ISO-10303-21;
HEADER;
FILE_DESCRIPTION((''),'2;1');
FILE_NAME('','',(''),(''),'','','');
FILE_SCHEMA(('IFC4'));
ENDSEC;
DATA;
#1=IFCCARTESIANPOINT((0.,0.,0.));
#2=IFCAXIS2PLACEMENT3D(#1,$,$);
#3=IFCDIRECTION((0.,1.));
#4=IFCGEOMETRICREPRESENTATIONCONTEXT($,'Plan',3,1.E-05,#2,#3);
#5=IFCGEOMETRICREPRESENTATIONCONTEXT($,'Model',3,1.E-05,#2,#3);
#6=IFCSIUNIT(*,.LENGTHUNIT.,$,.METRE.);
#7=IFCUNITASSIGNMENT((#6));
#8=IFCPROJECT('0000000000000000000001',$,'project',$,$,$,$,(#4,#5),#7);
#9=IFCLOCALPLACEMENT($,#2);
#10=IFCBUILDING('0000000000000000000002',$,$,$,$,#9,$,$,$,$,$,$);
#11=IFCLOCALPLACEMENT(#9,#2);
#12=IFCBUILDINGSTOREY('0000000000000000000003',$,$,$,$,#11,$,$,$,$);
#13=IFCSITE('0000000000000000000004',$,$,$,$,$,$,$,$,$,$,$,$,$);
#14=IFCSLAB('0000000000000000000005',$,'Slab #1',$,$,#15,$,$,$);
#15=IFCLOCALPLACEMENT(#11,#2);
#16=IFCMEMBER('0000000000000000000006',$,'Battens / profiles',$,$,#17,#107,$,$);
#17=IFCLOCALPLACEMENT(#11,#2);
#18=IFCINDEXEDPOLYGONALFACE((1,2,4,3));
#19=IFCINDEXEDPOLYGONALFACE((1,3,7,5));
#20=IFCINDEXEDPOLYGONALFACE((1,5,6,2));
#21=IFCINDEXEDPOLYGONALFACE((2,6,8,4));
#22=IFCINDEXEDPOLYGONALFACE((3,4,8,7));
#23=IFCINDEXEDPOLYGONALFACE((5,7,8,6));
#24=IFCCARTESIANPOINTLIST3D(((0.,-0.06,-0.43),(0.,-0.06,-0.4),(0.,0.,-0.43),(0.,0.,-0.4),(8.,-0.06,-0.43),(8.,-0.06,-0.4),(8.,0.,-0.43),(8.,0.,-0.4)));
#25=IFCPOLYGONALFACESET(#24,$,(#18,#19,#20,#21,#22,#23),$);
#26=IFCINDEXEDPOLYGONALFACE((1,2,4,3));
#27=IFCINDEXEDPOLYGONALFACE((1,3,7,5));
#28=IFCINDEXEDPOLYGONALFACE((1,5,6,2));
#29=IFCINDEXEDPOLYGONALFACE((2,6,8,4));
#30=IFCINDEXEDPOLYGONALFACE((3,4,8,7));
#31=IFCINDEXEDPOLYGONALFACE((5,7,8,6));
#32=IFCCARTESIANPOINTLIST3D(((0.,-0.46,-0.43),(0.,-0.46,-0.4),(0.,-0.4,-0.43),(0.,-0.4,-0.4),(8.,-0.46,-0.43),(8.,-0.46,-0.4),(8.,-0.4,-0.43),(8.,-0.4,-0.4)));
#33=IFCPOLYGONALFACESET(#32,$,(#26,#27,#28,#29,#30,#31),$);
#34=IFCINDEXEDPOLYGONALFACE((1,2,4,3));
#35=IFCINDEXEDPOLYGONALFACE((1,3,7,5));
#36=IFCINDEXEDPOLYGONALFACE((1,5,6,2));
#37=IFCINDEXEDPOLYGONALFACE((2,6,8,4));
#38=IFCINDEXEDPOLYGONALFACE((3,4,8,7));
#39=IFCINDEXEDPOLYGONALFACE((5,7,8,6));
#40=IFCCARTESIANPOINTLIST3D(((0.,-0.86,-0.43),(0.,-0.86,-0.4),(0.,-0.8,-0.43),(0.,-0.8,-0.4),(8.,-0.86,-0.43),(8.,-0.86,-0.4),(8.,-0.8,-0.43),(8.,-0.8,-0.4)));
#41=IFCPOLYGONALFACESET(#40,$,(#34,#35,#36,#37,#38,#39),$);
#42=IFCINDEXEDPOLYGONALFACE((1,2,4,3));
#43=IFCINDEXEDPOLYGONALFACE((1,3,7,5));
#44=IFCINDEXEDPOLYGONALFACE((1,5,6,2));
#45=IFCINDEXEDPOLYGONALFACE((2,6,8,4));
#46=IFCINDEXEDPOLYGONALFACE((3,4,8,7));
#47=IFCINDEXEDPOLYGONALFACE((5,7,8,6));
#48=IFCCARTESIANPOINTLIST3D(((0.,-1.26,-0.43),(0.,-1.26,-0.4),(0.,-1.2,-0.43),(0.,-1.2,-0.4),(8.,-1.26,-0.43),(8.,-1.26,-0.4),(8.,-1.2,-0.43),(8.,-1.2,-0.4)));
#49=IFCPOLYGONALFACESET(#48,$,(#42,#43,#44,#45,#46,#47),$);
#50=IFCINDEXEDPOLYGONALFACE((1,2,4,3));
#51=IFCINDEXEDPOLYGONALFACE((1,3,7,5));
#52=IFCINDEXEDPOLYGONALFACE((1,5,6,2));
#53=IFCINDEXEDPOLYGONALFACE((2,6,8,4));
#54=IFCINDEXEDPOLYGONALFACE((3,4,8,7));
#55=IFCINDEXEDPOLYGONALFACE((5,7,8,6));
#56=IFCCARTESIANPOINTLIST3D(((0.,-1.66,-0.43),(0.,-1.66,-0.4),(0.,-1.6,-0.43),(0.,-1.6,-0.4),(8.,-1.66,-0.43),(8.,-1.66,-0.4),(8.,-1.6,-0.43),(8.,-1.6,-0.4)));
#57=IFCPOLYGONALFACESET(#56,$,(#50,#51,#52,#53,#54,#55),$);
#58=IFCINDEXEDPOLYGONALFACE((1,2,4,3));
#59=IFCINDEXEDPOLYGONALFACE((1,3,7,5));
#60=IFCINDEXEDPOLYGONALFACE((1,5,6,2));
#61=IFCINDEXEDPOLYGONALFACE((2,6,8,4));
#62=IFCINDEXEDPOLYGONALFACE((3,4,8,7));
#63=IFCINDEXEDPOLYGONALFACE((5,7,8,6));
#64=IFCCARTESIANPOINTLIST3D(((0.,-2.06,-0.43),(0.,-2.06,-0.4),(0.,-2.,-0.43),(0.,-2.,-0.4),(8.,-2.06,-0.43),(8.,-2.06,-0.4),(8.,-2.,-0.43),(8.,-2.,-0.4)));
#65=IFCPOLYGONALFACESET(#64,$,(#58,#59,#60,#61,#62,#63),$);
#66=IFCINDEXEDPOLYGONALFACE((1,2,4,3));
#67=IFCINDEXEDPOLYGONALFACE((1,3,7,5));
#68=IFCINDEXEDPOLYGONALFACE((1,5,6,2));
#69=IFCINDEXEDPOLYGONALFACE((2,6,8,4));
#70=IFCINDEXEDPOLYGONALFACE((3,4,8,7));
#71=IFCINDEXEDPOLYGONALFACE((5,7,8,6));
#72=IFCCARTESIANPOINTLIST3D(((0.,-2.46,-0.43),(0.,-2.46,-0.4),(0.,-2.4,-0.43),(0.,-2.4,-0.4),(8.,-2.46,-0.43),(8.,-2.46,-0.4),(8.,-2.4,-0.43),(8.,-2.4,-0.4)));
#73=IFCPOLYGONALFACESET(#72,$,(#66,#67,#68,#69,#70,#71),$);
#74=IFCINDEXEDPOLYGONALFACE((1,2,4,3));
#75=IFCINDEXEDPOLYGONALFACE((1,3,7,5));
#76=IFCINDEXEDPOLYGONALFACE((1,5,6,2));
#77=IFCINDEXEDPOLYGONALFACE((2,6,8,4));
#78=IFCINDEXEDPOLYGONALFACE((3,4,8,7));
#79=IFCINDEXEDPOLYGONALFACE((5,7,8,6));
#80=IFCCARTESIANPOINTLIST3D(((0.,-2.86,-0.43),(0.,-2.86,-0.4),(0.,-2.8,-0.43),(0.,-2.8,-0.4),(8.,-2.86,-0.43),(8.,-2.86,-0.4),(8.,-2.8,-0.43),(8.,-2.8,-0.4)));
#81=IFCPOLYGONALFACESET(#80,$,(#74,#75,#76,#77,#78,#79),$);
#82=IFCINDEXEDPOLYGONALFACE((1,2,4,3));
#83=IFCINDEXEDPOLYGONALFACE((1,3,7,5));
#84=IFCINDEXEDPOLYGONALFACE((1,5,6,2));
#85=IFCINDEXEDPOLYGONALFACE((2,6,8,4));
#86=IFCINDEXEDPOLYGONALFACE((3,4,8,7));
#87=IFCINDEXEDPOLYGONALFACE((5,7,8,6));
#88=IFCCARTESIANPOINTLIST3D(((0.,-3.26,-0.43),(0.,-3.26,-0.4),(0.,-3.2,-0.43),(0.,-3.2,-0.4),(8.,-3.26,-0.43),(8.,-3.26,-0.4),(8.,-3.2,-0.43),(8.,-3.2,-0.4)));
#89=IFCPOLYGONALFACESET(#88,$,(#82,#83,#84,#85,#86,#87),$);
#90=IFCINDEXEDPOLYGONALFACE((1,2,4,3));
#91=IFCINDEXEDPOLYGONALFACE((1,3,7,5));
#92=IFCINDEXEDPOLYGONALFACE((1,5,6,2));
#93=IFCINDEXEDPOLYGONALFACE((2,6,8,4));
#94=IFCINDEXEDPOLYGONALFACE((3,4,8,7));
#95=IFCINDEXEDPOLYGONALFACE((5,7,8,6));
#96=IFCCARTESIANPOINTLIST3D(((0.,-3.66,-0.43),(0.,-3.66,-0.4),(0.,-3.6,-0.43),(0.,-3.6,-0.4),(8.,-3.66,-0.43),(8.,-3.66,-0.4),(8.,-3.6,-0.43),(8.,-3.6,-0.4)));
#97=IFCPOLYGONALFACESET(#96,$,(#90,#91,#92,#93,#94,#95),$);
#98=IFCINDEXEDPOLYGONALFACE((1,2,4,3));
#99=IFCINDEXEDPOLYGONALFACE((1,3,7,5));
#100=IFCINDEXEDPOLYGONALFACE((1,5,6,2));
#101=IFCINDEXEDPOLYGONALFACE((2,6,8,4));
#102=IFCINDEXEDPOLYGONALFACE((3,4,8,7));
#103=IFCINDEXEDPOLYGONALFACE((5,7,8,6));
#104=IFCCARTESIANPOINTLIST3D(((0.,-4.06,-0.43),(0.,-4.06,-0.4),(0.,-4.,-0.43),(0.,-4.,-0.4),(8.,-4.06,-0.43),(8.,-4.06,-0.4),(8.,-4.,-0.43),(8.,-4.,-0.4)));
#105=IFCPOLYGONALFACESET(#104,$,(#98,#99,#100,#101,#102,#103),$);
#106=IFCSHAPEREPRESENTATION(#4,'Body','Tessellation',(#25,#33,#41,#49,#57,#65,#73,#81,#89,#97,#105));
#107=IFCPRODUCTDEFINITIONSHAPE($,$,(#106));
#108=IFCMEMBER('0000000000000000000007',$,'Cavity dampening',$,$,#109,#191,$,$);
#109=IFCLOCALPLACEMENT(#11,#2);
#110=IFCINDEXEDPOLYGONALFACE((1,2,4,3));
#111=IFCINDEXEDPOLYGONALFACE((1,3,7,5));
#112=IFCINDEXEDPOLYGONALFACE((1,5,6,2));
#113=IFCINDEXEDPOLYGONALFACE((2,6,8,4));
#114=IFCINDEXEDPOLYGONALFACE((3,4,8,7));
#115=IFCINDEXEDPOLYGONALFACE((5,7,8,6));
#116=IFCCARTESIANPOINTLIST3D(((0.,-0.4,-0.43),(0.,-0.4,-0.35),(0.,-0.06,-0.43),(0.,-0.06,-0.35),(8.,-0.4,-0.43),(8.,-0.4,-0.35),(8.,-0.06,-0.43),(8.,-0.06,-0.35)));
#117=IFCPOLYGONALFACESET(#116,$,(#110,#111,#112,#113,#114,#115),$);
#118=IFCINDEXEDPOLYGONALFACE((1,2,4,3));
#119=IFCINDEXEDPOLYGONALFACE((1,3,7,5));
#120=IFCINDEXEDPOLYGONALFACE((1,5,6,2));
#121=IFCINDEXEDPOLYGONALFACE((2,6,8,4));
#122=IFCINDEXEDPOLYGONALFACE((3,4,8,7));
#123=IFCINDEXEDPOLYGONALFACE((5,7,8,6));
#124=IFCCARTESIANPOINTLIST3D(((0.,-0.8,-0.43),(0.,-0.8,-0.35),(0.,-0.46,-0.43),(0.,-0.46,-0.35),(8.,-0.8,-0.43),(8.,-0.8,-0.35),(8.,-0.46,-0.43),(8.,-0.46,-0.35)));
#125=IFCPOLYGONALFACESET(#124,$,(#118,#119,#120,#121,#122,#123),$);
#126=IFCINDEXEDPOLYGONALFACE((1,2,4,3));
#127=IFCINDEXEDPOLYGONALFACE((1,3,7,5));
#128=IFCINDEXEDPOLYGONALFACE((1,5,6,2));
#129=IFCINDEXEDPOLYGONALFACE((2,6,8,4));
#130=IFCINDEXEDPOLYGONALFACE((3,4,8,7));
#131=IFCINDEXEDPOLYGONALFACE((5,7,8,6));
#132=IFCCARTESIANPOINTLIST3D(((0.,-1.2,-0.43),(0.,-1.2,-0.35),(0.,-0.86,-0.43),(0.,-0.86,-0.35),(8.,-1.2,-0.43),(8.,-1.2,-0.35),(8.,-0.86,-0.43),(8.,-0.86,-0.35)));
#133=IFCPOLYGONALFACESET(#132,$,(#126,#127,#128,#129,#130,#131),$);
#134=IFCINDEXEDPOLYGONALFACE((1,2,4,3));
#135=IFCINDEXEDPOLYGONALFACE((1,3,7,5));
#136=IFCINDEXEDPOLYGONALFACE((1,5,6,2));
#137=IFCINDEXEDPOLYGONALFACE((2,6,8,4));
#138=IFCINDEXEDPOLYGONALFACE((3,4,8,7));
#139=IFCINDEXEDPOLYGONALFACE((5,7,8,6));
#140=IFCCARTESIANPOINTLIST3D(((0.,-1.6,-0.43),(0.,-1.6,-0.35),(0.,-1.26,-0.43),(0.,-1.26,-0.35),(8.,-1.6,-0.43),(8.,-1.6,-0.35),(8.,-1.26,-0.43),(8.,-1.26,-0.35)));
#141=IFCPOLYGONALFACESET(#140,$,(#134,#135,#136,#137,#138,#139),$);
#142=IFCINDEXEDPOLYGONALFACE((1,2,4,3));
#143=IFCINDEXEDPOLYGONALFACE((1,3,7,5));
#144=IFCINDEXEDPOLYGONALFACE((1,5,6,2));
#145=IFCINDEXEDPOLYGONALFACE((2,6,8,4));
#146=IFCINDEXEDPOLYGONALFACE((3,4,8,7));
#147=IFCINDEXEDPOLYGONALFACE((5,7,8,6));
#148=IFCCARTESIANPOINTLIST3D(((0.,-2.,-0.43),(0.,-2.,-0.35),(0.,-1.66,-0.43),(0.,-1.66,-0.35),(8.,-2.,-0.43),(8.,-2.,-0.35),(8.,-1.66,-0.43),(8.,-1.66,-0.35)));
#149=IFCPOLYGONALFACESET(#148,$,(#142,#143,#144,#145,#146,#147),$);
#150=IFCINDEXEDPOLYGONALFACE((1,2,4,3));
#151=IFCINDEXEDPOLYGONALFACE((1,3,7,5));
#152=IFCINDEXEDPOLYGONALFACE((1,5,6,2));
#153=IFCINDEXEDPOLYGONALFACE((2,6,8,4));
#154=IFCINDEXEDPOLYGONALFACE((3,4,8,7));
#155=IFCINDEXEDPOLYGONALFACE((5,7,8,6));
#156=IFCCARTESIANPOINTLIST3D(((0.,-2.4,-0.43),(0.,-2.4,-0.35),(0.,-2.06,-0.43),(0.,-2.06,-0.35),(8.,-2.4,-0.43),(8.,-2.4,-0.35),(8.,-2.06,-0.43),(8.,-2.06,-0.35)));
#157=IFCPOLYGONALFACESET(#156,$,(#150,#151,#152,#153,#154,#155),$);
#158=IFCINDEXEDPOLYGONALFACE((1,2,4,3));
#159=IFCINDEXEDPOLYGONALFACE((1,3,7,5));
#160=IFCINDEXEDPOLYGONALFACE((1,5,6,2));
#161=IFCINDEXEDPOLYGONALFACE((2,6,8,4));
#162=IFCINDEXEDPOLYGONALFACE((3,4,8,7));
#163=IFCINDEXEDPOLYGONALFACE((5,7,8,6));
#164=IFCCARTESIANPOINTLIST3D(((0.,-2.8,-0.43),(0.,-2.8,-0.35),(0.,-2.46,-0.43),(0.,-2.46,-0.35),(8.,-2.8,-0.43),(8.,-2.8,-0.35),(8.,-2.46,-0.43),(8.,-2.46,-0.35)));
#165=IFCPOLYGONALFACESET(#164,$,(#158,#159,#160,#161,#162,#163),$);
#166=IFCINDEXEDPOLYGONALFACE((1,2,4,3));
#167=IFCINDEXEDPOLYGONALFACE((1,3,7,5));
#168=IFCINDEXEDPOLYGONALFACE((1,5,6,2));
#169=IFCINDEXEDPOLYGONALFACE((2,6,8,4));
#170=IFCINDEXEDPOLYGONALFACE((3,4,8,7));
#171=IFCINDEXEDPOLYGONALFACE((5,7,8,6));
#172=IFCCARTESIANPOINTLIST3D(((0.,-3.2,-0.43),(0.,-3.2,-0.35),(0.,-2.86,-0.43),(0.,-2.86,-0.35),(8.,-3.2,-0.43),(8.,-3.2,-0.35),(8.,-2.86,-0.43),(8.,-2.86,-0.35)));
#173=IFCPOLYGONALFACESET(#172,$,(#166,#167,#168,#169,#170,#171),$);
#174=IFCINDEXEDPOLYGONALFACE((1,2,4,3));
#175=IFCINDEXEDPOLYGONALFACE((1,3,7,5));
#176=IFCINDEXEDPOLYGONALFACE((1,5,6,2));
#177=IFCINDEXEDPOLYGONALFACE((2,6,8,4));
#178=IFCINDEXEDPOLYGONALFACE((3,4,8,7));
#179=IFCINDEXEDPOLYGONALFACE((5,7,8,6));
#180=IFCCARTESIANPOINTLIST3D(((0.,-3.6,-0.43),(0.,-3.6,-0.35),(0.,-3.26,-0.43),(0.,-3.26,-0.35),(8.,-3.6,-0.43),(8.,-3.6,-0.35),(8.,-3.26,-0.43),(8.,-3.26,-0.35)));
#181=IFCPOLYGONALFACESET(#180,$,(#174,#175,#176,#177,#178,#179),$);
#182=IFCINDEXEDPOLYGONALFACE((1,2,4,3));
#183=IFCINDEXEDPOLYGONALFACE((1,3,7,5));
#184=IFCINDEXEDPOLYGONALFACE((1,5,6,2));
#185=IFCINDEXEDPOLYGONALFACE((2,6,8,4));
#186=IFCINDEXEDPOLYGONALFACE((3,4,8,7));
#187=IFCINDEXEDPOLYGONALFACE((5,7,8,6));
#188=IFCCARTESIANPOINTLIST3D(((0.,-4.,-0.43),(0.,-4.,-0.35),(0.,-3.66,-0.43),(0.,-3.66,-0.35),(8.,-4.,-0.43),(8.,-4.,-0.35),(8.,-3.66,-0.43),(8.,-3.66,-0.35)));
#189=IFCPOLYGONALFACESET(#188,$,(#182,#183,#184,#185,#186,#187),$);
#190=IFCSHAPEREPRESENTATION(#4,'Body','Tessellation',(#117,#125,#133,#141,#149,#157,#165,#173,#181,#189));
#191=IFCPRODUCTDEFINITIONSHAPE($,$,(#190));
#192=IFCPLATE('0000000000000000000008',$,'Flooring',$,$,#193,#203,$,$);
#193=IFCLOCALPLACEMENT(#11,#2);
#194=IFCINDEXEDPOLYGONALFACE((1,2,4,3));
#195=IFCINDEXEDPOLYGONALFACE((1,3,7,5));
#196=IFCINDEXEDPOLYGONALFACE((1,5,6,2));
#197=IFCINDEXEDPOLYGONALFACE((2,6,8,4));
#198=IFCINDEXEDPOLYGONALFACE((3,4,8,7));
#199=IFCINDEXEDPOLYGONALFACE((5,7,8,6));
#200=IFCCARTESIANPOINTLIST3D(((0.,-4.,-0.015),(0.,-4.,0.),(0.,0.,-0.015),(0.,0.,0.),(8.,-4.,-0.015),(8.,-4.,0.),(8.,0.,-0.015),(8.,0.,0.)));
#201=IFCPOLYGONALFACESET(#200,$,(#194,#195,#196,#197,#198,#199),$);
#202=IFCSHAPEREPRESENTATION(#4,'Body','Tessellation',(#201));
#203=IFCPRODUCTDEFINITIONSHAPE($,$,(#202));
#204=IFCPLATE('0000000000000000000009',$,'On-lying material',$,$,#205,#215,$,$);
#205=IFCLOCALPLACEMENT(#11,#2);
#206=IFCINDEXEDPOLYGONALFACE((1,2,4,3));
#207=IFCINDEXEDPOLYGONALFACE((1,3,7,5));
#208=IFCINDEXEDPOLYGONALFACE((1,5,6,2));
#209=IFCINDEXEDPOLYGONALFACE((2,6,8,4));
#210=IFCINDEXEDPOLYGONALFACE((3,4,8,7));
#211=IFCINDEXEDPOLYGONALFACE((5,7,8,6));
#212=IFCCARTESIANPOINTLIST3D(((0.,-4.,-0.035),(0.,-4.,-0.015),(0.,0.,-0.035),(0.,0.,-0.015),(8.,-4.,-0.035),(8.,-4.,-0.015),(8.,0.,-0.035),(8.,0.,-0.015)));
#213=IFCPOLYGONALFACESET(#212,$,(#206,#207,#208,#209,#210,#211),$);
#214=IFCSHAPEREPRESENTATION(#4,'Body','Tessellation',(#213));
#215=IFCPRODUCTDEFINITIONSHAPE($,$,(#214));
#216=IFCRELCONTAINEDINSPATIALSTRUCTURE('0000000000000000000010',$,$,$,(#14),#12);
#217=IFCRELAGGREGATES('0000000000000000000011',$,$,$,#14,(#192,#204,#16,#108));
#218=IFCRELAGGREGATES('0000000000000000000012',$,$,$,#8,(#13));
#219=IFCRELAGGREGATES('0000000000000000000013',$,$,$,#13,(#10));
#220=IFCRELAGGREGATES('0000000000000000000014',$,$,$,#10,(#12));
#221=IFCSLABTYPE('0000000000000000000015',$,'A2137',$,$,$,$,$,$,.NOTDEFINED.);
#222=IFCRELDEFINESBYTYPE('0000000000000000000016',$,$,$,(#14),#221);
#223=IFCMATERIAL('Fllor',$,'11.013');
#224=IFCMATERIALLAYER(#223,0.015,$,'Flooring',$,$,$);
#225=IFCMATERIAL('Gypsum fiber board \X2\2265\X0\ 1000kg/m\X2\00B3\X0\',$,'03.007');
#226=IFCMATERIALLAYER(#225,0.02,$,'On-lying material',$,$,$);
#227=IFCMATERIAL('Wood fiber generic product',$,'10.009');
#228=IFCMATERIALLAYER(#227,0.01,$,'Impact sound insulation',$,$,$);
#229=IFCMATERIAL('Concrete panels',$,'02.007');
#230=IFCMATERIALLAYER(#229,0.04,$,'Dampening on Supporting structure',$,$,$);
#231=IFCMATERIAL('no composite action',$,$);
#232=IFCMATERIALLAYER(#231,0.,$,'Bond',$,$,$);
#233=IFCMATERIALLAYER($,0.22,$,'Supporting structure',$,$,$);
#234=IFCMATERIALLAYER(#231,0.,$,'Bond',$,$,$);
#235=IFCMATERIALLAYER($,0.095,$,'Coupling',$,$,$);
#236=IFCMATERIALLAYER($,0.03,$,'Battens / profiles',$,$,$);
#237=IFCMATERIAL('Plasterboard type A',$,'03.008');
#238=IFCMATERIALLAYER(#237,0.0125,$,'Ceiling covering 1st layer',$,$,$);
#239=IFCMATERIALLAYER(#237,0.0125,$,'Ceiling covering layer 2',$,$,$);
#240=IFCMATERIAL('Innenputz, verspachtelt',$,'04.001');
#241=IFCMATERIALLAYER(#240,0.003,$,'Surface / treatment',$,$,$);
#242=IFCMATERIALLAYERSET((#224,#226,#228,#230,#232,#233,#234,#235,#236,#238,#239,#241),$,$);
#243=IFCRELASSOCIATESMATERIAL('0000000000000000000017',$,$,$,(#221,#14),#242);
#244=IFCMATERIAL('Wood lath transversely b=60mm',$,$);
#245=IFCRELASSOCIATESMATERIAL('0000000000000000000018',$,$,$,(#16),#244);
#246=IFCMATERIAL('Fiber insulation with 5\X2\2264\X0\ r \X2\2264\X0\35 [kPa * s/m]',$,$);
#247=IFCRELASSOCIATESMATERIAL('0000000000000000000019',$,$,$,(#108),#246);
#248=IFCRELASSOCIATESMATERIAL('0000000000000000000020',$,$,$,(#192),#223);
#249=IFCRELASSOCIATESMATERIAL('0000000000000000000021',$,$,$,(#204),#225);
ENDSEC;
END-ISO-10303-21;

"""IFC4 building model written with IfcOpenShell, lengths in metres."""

from ifc_helpers import new_model, si_unit, direction, frame, frame_2d, origin, origin_with_axes, place, context, project, spatial, rectangle, extrude, material, layer, layer_set, type_object, element, aggregate, save


model = new_model("IFC4")

# Units and contexts
plan_context = context("Plan", 3, precision=1e-05, world=origin(), true_north=direction((0.0, 1.0)))
model_context = context("Model", 3, precision=1e-05, world=origin(), true_north=direction((0.0, 1.0)))
ifc_project = project(units=[si_unit("LENGTHUNIT", "METRE")], contexts=[plan_context, model_context])

# Site, building, storey
site = spatial("IfcSite", under=ifc_project)
building_placement = place(None, origin())
building = spatial("IfcBuilding", under=site, at=building_placement)
storey_placement = place(building_placement, origin())
storey = spatial("IfcBuildingStorey", under=building, at=storey_placement)

# Slab, members, plates
ifc_material_1 = material(Name="Fllor", Category="11.013")
ifc_layer_1 = layer(ifc_material_1, 0.015, Name="Flooring")
ifc_material_2 = material(Name="Gypsum fiber board ≥ 1000kg/m³", Category="03.007")
ifc_layer_2 = layer(ifc_material_2, 0.02, Name="On-lying material")
ifc_material_3 = material(Name="Wood fiber generic product", Category="10.009")
ifc_layer_3 = layer(ifc_material_3, 0.01, Name="Impact sound insulation")
ifc_material_4 = material(Name="Concrete panels", Category="02.007")
ifc_layer_4 = layer(ifc_material_4, 0.04, Name="Dampening on Supporting structure")
ifc_material_5 = material(Name="no composite action")
ifc_layer_5 = layer(ifc_material_5, 0.0, Name="Bond")
ifc_layer_6 = layer(None, 0.22, Name="Supporting structure")
ifc_layer_7 = layer(ifc_material_5, 0.0, Name="Bond")
ifc_layer_8 = layer(None, 0.095, Name="Coupling")
ifc_layer_9 = layer(None, 0.03, Name="Battens / profiles")
ifc_material_6 = material(Name="Plasterboard type A", Category="03.008")
ifc_layer_10 = layer(ifc_material_6, 0.0125, Name="Ceiling covering 1st layer")
ifc_layer_11 = layer(ifc_material_6, 0.0125, Name="Ceiling covering layer 2")
ifc_material_7 = material(Name="Innenputz, verspachtelt", Category="04.001")
ifc_layer_12 = layer(ifc_material_7, 0.003, Name="Surface / treatment")
ifc_layer_set = layer_set([ifc_layer_1, ifc_layer_2, ifc_layer_3, ifc_layer_4, ifc_layer_5, ifc_layer_6, ifc_layer_7, ifc_layer_8, ifc_layer_9, ifc_layer_10, ifc_layer_11, ifc_layer_12])
slab_type = type_object("IfcSlabType", Name="A2137", PredefinedType="NOTDEFINED", material=ifc_layer_set)
slab_placement = place(None, frame((0.0, 0.0, 0.0), z_axis=(0.0, 0.0, -1.0), x_axis=(1.0, 0.0, 0.0)))
slab = element("IfcSlab", 1, at=slab_placement, inside=storey, type_object=slab_type, material=ifc_layer_set, Name="Slab #1")
ifc_material_8 = material(Name="Wood lath transversely b=60mm")
member_1_placement = place(slab_placement, origin())
member_1 = element("IfcMember", 2, at=member_1_placement, material=ifc_material_8, Name="Battens / profiles", context=plan_context, shape_type="SweptSolid", body=[
    extrude(rectangle(XDim=0.06, YDim=0.03, at=frame_2d((0.03, 0.015), x_axis=(1.0, 0.0))), frame((0.0, 0.0, 0.4), z_axis=(1.0, 0.0, 0.0), x_axis=(0.0, 1.0, 0.0)), (0.0, 0.0, 1.0), 8.0),
    extrude(rectangle(XDim=0.06, YDim=0.03, at=frame_2d((0.03, 0.015), x_axis=(1.0, 0.0))), frame((0.0, 0.4, 0.4), z_axis=(1.0, 0.0, 0.0), x_axis=(0.0, 1.0, 0.0)), (0.0, 0.0, 1.0), 8.0),
    extrude(rectangle(XDim=0.06, YDim=0.03, at=frame_2d((0.03, 0.015), x_axis=(1.0, 0.0))), frame((0.0, 0.8, 0.4), z_axis=(1.0, 0.0, 0.0), x_axis=(0.0, 1.0, 0.0)), (0.0, 0.0, 1.0), 8.0),
    extrude(rectangle(XDim=0.06, YDim=0.03, at=frame_2d((0.03, 0.015), x_axis=(1.0, 0.0))), frame((0.0, 1.2, 0.4), z_axis=(1.0, 0.0, 0.0), x_axis=(0.0, 1.0, 0.0)), (0.0, 0.0, 1.0), 8.0),
    extrude(rectangle(XDim=0.06, YDim=0.03, at=frame_2d((0.03, 0.015), x_axis=(1.0, 0.0))), frame((0.0, 1.6, 0.4), z_axis=(1.0, 0.0, 0.0), x_axis=(0.0, 1.0, 0.0)), (0.0, 0.0, 1.0), 8.0),
    extrude(rectangle(XDim=0.06, YDim=0.03, at=frame_2d((0.03, 0.015), x_axis=(1.0, 0.0))), frame((0.0, 2.0, 0.4), z_axis=(1.0, 0.0, 0.0), x_axis=(0.0, 1.0, 0.0)), (0.0, 0.0, 1.0), 8.0),
    extrude(rectangle(XDim=0.06, YDim=0.03, at=frame_2d((0.03, 0.015), x_axis=(1.0, 0.0))), frame((0.0, 2.4, 0.4), z_axis=(1.0, 0.0, 0.0), x_axis=(0.0, 1.0, 0.0)), (0.0, 0.0, 1.0), 8.0),
    extrude(rectangle(XDim=0.06, YDim=0.03, at=frame_2d((0.03, 0.015), x_axis=(1.0, 0.0))), frame((0.0, 2.8, 0.4), z_axis=(1.0, 0.0, 0.0), x_axis=(0.0, 1.0, 0.0)), (0.0, 0.0, 1.0), 8.0),
    extrude(rectangle(XDim=0.06, YDim=0.03, at=frame_2d((0.03, 0.015), x_axis=(1.0, 0.0))), frame((0.0, 3.2, 0.4), z_axis=(1.0, 0.0, 0.0), x_axis=(0.0, 1.0, 0.0)), (0.0, 0.0, 1.0), 8.0),
    extrude(rectangle(XDim=0.06, YDim=0.03, at=frame_2d((0.03, 0.015), x_axis=(1.0, 0.0))), frame((0.0, 3.6, 0.4), z_axis=(1.0, 0.0, 0.0), x_axis=(0.0, 1.0, 0.0)), (0.0, 0.0, 1.0), 8.0),
    extrude(rectangle(XDim=0.06, YDim=0.03, at=frame_2d((0.03, 0.015), x_axis=(1.0, 0.0))), frame((0.0, 4.0, 0.4), z_axis=(1.0, 0.0, 0.0), x_axis=(0.0, 1.0, 0.0)), (0.0, 0.0, 1.0), 8.0),
])
ifc_material_9 = material(Name="Fiber insulation with 5≤ r ≤35 [kPa * s/m]")
member_2_placement = place(slab_placement, origin())
member_2 = element("IfcMember", 3, at=member_2_placement, material=ifc_material_9, Name="Cavity dampening", context=plan_context, shape_type="SweptSolid", body=[
    extrude(rectangle(XDim=0.34, YDim=0.08, at=frame_2d((0.17, 0.04), x_axis=(1.0, 0.0))), frame((0.0, 0.06, 0.35), z_axis=(1.0, 0.0, 0.0), x_axis=(0.0, 1.0, 0.0)), (0.0, 0.0, 1.0), 8.0),
    extrude(rectangle(XDim=0.34, YDim=0.08, at=frame_2d((0.17, 0.04), x_axis=(1.0, 0.0))), frame((0.0, 0.46, 0.35), z_axis=(1.0, 0.0, 0.0), x_axis=(0.0, 1.0, 0.0)), (0.0, 0.0, 1.0), 8.0),
    extrude(rectangle(XDim=0.34, YDim=0.08, at=frame_2d((0.17, 0.04), x_axis=(1.0, 0.0))), frame((0.0, 0.86, 0.35), z_axis=(1.0, 0.0, 0.0), x_axis=(0.0, 1.0, 0.0)), (0.0, 0.0, 1.0), 8.0),
    extrude(rectangle(XDim=0.34, YDim=0.08, at=frame_2d((0.17, 0.04), x_axis=(1.0, 0.0))), frame((0.0, 1.26, 0.35), z_axis=(1.0, 0.0, 0.0), x_axis=(0.0, 1.0, 0.0)), (0.0, 0.0, 1.0), 8.0),
    extrude(rectangle(XDim=0.34, YDim=0.08, at=frame_2d((0.17, 0.04), x_axis=(1.0, 0.0))), frame((0.0, 1.66, 0.35), z_axis=(1.0, 0.0, 0.0), x_axis=(0.0, 1.0, 0.0)), (0.0, 0.0, 1.0), 8.0),
    extrude(rectangle(XDim=0.34, YDim=0.08, at=frame_2d((0.17, 0.04), x_axis=(1.0, 0.0))), frame((0.0, 2.06, 0.35), z_axis=(1.0, 0.0, 0.0), x_axis=(0.0, 1.0, 0.0)), (0.0, 0.0, 1.0), 8.0),
    extrude(rectangle(XDim=0.34, YDim=0.08, at=frame_2d((0.17, 0.04), x_axis=(1.0, 0.0))), frame((0.0, 2.46, 0.35), z_axis=(1.0, 0.0, 0.0), x_axis=(0.0, 1.0, 0.0)), (0.0, 0.0, 1.0), 8.0),
    extrude(rectangle(XDim=0.34, YDim=0.08, at=frame_2d((0.17, 0.04), x_axis=(1.0, 0.0))), frame((0.0, 2.86, 0.35), z_axis=(1.0, 0.0, 0.0), x_axis=(0.0, 1.0, 0.0)), (0.0, 0.0, 1.0), 8.0),
    extrude(rectangle(XDim=0.34, YDim=0.08, at=frame_2d((0.17, 0.04), x_axis=(1.0, 0.0))), frame((0.0, 3.26, 0.35), z_axis=(1.0, 0.0, 0.0), x_axis=(0.0, 1.0, 0.0)), (0.0, 0.0, 1.0), 8.0),
    extrude(rectangle(XDim=0.34, YDim=0.08, at=frame_2d((0.17, 0.04), x_axis=(1.0, 0.0))), frame((0.0, 3.66, 0.35), z_axis=(1.0, 0.0, 0.0), x_axis=(0.0, 1.0, 0.0)), (0.0, 0.0, 1.0), 8.0),
])
plate_1_placement = place(slab_placement, origin())
plate_1 = element("IfcPlate", 4, at=plate_1_placement, material=ifc_material_1, Name="Flooring", context=plan_context, shape_type="SweptSolid", body=[
    extrude(rectangle(XDim=8.0, YDim=4.0, at=frame_2d((4.0, 2.0), x_axis=(1.0, 0.0))), origin_with_axes(), (0.0, 0.0, 1.0), 0.015),
])
plate_2_placement = place(slab_placement, origin())
plate_2 = element("IfcPlate", 5, at=plate_2_placement, material=ifc_material_2, Name="On-lying material", context=plan_context, shape_type="SweptSolid", body=[
    extrude(rectangle(XDim=8.0, YDim=4.0, at=frame_2d((4.0, 2.0), x_axis=(1.0, 0.0))), frame((0.0, 0.0, 0.015), z_axis=(0.0, 0.0, 1.0), x_axis=(1.0, 0.0, 0.0)), (0.0, 0.0, 1.0), 0.02),
])
aggregate(slab, [plate_1, plate_2, member_1, member_2])

save(model, "model.ifc")
